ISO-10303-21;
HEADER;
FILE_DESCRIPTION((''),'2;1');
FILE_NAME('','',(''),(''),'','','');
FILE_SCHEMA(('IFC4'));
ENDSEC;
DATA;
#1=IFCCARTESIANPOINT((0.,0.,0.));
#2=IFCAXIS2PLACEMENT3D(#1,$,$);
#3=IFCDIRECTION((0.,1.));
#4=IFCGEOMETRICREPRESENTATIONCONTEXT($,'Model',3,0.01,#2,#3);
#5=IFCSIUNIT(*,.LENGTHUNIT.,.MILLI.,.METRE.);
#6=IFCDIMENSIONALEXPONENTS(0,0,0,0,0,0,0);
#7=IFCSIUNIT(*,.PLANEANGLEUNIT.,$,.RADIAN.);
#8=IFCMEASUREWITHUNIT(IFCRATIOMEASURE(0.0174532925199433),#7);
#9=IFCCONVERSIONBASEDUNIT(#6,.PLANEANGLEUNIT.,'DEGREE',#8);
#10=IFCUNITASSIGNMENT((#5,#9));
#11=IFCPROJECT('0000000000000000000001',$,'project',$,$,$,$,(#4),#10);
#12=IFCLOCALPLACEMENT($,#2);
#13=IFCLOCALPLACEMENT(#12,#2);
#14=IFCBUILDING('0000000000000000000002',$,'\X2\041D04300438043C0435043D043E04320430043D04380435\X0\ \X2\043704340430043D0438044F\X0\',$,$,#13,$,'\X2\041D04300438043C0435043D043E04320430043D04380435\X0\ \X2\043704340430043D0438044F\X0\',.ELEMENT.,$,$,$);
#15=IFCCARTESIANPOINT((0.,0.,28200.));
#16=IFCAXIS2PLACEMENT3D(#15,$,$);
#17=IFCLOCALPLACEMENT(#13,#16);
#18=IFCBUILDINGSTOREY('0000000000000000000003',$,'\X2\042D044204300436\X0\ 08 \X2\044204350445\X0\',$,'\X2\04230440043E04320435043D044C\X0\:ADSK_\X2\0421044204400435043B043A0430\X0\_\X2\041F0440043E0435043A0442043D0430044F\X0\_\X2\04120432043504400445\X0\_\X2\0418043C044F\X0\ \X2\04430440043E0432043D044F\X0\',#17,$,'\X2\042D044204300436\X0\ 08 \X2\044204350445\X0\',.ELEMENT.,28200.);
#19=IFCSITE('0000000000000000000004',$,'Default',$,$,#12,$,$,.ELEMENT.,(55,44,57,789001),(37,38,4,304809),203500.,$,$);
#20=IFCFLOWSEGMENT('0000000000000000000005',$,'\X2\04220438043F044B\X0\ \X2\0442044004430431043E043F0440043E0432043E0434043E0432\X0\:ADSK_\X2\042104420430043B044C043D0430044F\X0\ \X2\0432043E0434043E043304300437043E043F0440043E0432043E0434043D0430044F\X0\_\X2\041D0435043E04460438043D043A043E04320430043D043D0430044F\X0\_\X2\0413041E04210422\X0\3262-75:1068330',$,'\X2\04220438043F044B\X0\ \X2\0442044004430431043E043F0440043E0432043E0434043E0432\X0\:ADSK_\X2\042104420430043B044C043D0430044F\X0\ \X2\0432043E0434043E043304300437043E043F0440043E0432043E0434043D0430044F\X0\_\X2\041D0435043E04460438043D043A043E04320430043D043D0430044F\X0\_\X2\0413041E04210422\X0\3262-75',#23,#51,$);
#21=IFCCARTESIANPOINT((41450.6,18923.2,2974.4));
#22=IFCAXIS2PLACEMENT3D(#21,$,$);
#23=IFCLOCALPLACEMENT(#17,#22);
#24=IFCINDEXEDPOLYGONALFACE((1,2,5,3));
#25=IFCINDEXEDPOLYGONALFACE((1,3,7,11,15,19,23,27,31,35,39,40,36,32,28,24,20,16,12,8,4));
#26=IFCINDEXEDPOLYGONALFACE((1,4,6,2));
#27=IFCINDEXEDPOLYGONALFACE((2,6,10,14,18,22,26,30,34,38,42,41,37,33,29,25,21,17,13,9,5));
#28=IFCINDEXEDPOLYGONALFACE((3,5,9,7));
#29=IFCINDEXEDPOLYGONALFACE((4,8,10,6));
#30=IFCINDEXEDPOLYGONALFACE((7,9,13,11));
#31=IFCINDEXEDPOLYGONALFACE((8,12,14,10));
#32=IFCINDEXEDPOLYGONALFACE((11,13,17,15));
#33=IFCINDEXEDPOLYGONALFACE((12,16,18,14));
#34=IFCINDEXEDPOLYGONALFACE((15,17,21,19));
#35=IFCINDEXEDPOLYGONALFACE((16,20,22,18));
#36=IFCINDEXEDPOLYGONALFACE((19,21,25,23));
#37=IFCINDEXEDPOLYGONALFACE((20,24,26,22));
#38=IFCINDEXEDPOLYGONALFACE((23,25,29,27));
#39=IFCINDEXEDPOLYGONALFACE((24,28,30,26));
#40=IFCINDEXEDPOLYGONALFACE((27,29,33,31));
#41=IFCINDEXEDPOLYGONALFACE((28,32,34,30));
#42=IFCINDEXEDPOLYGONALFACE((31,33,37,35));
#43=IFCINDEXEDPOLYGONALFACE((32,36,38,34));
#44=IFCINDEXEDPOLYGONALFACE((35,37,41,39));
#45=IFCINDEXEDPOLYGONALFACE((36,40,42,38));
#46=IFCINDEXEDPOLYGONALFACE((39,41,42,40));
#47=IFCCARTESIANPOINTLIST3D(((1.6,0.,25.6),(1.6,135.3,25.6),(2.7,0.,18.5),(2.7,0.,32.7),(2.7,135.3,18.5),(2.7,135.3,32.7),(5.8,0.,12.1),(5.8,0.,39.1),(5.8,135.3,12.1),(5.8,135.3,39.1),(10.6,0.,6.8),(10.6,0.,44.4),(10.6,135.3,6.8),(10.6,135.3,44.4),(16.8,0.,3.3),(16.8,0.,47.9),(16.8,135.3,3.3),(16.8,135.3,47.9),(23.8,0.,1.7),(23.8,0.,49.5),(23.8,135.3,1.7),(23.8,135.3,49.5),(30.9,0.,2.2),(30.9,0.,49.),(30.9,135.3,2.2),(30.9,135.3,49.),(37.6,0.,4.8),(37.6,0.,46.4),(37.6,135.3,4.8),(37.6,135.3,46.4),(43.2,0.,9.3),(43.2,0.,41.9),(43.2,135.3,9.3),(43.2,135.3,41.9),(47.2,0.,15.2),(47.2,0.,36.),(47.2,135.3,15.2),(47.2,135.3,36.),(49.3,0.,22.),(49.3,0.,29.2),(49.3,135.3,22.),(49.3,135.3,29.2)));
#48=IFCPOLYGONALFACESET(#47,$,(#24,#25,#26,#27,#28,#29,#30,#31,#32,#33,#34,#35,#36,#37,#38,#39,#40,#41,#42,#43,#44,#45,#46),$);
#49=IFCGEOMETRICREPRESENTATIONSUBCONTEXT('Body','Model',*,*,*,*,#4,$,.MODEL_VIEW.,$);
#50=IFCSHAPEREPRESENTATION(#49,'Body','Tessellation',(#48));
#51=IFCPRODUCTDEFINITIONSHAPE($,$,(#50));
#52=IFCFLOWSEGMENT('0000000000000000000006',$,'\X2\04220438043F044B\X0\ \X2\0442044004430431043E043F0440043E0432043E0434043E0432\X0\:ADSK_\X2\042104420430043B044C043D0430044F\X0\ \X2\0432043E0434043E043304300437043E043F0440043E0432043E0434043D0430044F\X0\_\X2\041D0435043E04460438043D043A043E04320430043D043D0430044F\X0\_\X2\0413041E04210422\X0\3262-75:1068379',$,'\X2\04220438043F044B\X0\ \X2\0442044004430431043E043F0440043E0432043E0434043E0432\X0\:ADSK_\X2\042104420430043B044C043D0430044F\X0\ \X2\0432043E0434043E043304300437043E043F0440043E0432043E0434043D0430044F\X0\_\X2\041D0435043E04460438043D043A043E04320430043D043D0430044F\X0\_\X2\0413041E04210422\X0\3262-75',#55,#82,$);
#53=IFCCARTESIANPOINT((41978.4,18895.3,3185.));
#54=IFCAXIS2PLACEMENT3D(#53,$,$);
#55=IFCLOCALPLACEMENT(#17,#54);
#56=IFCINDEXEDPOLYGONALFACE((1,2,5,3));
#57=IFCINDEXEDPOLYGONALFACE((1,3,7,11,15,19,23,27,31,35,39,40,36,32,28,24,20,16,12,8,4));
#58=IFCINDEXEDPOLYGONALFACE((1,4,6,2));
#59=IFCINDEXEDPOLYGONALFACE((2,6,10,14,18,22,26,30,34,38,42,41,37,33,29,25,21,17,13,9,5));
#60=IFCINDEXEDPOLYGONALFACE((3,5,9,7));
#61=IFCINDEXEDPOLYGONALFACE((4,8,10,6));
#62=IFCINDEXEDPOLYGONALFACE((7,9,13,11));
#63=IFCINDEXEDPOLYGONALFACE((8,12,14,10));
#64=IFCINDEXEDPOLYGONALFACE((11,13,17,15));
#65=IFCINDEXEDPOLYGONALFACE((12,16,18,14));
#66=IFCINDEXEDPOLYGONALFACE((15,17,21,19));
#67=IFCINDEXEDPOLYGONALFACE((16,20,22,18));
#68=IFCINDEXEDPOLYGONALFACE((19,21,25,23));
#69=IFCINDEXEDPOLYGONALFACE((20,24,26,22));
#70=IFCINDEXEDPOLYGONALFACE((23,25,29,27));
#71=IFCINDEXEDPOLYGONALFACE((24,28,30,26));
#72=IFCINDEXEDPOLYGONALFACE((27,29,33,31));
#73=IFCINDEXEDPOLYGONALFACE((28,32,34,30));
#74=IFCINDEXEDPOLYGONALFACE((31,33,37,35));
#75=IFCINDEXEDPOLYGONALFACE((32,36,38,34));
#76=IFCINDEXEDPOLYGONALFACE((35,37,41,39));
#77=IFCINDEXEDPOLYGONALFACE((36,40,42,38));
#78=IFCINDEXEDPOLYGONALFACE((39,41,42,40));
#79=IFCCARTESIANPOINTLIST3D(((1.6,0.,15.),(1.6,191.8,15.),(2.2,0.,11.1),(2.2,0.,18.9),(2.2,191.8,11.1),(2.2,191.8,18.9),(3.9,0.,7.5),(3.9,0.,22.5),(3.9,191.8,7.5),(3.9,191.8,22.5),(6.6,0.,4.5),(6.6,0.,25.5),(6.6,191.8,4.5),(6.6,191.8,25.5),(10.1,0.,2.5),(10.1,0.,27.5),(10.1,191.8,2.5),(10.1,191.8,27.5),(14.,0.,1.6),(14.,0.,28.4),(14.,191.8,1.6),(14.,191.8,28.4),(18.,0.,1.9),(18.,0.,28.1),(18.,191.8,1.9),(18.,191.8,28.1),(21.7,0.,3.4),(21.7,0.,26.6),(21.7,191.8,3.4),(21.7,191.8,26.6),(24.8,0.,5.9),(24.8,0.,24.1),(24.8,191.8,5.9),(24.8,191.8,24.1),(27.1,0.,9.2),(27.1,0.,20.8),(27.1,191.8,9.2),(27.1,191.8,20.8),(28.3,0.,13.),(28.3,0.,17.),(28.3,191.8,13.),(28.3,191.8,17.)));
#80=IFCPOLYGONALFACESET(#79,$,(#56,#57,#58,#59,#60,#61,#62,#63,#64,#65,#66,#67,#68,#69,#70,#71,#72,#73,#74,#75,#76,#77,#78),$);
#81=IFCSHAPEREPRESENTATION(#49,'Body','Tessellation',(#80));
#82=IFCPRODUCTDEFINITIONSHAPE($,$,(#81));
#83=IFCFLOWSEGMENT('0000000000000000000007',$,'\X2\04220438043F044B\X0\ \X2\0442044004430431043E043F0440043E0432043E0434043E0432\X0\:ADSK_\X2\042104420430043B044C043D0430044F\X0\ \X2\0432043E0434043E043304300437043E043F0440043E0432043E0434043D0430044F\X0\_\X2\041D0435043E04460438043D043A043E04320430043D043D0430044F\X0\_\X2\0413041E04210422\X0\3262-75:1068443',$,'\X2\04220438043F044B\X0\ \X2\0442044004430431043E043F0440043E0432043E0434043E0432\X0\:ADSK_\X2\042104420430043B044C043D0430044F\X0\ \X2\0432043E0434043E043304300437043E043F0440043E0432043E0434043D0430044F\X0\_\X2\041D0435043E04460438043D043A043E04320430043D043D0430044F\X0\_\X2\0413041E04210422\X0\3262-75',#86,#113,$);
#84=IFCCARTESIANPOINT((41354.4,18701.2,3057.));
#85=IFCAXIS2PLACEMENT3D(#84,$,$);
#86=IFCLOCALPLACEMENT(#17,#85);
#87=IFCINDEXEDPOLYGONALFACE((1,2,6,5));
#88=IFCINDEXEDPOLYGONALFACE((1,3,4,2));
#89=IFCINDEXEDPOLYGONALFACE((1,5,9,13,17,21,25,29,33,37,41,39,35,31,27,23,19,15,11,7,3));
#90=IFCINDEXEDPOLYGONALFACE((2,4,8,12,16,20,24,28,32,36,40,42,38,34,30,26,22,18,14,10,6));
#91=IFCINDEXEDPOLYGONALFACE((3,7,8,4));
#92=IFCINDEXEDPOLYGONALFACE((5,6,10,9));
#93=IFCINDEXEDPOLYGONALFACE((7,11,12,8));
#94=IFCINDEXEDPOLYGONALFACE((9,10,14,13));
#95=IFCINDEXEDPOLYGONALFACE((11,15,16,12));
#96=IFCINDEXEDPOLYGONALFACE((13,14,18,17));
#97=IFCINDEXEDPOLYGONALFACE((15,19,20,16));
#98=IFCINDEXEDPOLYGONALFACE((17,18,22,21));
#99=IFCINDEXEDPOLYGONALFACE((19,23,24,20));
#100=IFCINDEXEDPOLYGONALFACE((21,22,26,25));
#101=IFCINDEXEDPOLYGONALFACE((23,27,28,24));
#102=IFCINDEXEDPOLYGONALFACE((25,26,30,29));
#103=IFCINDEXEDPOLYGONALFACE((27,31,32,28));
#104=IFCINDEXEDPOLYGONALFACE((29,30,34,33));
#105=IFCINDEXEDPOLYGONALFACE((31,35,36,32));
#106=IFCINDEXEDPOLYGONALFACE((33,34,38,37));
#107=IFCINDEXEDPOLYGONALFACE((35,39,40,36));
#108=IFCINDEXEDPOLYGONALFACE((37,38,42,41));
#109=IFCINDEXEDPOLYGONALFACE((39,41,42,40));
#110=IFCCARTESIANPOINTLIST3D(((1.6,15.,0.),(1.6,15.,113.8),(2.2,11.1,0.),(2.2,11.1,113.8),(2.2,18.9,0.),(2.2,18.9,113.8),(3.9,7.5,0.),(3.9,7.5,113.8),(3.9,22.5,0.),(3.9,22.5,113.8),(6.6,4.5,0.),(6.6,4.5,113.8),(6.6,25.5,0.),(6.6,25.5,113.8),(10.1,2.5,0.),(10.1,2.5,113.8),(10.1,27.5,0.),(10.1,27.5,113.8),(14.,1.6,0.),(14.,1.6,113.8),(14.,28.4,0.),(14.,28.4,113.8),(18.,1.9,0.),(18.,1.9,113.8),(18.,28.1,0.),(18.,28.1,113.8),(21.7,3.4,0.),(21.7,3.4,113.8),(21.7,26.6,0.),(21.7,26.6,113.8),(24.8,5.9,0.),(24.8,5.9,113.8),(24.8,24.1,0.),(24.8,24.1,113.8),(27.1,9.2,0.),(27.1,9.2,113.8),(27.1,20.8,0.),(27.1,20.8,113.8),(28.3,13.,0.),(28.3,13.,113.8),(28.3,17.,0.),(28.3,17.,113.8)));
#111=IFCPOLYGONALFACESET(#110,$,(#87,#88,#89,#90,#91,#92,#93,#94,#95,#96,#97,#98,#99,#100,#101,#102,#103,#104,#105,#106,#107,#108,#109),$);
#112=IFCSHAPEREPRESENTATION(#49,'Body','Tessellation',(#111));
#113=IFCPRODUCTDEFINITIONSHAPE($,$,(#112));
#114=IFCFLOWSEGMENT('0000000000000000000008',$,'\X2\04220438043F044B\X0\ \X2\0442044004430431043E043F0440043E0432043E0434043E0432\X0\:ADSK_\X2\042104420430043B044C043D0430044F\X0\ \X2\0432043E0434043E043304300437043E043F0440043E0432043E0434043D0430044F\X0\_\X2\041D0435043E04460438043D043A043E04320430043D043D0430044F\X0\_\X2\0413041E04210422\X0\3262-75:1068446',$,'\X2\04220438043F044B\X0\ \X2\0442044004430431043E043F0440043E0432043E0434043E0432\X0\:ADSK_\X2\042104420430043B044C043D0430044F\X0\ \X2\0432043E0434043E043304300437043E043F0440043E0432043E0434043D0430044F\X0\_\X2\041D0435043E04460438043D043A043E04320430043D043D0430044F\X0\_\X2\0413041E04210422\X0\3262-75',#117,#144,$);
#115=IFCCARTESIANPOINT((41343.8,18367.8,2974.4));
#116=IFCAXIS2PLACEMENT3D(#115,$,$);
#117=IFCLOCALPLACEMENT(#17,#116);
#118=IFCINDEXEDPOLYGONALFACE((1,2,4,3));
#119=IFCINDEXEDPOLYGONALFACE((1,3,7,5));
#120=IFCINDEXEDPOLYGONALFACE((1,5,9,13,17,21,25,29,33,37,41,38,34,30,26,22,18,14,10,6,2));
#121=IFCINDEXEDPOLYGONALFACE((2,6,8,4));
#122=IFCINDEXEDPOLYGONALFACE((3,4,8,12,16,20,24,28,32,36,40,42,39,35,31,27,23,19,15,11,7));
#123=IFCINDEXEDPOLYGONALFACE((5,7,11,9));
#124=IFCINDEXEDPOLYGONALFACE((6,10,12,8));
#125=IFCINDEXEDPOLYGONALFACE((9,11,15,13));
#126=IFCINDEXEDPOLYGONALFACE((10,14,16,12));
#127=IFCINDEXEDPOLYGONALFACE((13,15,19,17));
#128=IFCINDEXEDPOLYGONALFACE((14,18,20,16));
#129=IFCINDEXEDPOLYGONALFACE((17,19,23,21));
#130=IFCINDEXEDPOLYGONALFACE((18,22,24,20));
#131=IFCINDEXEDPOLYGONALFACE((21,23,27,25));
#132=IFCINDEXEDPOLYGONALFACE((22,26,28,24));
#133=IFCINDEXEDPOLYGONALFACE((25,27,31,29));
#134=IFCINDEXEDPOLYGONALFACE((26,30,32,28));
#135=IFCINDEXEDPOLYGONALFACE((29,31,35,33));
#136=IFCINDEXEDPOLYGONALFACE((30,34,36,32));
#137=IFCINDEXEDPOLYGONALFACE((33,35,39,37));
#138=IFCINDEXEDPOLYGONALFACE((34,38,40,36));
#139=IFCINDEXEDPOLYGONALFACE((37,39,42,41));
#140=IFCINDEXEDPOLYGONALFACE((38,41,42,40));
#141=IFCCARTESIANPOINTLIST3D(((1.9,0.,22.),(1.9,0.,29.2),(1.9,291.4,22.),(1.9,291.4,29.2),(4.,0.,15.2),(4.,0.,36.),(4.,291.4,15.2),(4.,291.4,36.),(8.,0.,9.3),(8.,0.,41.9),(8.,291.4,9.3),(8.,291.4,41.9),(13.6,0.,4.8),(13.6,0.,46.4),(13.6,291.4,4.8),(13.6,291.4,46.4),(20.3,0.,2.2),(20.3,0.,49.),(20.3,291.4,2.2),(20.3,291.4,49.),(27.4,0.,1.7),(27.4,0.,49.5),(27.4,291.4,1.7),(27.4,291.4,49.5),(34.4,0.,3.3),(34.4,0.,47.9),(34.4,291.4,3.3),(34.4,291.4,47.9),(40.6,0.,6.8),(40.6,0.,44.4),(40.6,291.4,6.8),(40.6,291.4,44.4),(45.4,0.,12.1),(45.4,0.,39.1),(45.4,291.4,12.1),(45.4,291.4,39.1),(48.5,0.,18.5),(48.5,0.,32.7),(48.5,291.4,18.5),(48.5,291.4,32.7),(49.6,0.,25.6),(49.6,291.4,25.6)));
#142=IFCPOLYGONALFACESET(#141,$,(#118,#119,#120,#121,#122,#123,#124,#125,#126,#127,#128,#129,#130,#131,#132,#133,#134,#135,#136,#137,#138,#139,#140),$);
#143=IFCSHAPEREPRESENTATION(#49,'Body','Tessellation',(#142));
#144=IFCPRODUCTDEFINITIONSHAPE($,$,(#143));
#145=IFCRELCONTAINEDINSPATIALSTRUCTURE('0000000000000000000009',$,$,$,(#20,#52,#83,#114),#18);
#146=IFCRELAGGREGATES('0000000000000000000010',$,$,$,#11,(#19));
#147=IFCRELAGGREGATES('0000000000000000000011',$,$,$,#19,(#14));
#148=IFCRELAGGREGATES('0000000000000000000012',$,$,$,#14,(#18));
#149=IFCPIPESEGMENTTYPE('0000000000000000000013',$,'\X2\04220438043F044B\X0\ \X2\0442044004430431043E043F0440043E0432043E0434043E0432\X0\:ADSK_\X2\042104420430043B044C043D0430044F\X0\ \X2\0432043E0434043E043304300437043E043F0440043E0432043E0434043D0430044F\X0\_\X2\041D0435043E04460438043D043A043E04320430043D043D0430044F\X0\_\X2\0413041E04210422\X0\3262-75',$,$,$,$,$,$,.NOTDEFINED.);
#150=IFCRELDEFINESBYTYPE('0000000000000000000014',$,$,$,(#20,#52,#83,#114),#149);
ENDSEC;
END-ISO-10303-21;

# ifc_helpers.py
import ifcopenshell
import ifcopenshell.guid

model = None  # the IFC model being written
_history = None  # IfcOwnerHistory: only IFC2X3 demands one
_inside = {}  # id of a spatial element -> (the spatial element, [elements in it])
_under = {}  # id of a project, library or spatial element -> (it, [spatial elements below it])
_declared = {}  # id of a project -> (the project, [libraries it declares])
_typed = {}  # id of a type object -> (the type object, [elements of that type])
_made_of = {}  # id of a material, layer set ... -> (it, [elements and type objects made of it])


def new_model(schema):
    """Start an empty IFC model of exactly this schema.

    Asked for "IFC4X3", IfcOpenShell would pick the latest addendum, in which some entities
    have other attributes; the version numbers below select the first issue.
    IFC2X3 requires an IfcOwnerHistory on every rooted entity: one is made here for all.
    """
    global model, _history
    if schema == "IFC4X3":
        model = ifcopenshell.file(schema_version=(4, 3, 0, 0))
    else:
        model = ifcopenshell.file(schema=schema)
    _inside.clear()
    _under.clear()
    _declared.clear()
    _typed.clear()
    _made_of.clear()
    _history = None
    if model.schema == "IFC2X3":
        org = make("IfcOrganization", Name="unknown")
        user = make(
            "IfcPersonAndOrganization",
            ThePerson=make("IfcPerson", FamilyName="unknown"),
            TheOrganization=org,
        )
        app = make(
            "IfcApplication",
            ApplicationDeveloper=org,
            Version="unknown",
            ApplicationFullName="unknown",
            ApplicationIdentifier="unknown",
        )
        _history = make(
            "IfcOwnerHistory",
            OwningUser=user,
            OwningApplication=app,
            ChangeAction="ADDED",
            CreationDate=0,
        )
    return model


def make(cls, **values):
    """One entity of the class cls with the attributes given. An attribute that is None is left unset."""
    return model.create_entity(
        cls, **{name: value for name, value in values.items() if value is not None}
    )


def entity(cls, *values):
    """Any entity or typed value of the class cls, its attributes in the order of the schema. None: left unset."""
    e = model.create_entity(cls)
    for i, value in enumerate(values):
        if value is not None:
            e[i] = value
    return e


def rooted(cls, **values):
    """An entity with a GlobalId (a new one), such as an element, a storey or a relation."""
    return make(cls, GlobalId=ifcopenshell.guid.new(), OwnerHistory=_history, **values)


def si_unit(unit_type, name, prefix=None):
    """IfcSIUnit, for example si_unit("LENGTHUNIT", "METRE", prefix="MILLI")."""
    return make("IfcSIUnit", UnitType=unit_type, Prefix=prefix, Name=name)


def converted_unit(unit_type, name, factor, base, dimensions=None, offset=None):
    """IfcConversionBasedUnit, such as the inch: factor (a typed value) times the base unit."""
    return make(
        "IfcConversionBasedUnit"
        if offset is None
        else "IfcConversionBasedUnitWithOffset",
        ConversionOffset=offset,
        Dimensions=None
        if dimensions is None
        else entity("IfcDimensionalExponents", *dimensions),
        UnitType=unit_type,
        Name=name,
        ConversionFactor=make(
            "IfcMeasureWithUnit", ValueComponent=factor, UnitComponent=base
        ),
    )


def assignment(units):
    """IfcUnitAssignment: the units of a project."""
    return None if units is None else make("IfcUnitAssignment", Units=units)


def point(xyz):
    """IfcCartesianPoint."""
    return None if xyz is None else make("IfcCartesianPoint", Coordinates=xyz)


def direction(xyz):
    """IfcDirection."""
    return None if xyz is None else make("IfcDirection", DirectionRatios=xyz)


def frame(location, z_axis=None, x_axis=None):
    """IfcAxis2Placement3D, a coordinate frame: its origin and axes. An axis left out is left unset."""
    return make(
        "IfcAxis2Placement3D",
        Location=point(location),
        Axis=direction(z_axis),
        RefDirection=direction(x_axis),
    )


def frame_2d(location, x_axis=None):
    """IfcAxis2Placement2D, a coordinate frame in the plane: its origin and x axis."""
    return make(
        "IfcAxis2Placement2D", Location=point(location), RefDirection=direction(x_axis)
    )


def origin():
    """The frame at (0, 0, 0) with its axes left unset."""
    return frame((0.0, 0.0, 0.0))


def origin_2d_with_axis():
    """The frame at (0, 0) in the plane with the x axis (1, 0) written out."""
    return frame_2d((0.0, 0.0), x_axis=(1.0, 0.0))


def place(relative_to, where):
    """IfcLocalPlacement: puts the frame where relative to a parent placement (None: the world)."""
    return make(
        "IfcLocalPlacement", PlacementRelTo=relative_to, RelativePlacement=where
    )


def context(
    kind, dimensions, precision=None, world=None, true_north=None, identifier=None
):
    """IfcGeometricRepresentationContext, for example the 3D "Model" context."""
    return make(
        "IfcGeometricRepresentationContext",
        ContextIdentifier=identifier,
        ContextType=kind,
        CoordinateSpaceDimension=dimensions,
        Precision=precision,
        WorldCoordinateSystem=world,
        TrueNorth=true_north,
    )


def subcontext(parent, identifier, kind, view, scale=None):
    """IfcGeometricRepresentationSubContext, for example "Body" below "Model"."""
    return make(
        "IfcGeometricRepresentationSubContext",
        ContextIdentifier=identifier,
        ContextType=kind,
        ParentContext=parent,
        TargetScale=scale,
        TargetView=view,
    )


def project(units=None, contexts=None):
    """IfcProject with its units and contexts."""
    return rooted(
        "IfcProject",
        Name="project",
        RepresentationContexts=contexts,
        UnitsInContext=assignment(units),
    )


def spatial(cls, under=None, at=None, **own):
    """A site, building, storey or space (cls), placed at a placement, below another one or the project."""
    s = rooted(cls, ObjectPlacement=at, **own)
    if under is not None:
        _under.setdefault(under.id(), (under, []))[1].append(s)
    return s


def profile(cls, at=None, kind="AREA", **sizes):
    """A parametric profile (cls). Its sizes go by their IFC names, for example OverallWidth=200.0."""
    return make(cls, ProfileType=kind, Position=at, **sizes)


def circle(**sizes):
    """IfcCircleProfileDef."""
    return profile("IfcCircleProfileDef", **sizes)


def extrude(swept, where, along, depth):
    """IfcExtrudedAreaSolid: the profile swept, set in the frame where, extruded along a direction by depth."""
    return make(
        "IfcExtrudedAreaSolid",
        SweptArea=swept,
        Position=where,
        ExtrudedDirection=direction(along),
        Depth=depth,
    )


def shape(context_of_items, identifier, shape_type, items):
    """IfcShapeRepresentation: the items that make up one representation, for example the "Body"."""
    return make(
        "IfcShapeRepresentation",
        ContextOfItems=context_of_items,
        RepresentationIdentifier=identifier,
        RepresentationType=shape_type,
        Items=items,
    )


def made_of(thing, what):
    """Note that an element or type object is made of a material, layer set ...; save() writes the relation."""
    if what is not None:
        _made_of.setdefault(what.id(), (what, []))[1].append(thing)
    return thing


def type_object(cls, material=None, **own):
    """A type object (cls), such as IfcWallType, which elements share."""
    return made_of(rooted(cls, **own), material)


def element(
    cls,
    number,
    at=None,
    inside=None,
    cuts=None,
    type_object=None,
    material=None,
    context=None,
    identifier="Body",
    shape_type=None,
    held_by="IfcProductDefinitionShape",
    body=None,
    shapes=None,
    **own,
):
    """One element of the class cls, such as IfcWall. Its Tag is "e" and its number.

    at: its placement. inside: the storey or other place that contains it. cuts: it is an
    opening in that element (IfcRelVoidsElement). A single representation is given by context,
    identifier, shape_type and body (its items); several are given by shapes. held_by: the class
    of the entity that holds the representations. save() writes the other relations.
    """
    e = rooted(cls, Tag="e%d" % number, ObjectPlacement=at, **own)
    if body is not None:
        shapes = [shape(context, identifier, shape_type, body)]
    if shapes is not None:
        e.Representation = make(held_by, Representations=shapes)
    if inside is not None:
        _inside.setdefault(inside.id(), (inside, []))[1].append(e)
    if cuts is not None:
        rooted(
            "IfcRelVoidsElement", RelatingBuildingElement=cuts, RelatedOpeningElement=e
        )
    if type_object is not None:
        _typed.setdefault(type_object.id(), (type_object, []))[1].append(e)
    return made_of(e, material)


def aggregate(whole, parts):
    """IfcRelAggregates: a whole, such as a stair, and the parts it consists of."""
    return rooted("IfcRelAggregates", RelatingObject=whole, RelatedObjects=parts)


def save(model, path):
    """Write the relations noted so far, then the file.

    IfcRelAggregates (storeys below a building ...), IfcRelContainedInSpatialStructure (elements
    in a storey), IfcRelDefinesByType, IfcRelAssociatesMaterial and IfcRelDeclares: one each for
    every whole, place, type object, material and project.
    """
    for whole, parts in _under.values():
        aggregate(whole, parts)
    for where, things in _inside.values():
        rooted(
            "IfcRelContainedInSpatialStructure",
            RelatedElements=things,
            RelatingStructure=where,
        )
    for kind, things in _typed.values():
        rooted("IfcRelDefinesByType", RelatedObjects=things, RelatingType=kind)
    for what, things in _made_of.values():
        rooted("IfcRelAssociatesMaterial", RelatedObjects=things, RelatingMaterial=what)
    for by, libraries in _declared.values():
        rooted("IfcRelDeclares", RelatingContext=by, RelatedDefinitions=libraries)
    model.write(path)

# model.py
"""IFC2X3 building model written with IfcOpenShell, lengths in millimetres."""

from ifc_helpers import new_model, entity, si_unit, converted_unit, direction, frame, origin, origin_2d_with_axis, place, context, subcontext, project, spatial, circle, extrude, type_object, element, save


model = new_model("IFC2X3")

# Units and contexts
model_context = context("Model", 3, precision=0.01, world=origin(), true_north=direction((0.0, 1.0)))
body_context = subcontext(model_context, "Body", "Model", "MODEL_VIEW")
ifc_project = project(units=[si_unit("LENGTHUNIT", "METRE", prefix="MILLI"), converted_unit("PLANEANGLEUNIT", "DEGREE", entity("IfcRatioMeasure", 0.0174532925199433), si_unit("PLANEANGLEUNIT", "RADIAN"), dimensions=[0, 0, 0, 0, 0, 0, 0])], contexts=[model_context])

# Site, building, storey
site_placement = place(None, origin())
site = spatial("IfcSite", under=ifc_project, at=site_placement, Name="Default", CompositionType="ELEMENT", RefLatitude=(55, 44, 57, 789001), RefLongitude=(37, 38, 4, 304809), RefElevation=203500.0)
building_placement = place(site_placement, origin())
building = spatial("IfcBuilding", under=site, at=building_placement, Name="Наименование здания", LongName="Наименование здания", CompositionType="ELEMENT")
storey_placement = place(building_placement, frame((0.0, 0.0, 28200.0)))
storey = spatial("IfcBuildingStorey", under=building, at=storey_placement, Name="Этаж 08 тех", ObjectType="Уровень:ADSK_Стрелка_Проектная_Вверх_Имя уровня", LongName="Этаж 08 тех", CompositionType="ELEMENT", Elevation=28200.0)

# Flow segments
pipe_segment_type = type_object("IfcPipeSegmentType", Name="Типы трубопроводов:ADSK_Стальная водогазопроводная_Неоцинкованная_ГОСТ3262-75", PredefinedType="NOTDEFINED")
flow_segment_1_placement = place(storey_placement, frame((41450.6, 18923.2, 2974.4)))
element("IfcFlowSegment", 1, at=flow_segment_1_placement, inside=storey, type_object=pipe_segment_type, Name="Типы трубопроводов:ADSK_Стальная водогазопроводная_Неоцинкованная_ГОСТ3262-75:1068330", ObjectType="Типы трубопроводов:ADSK_Стальная водогазопроводная_Неоцинкованная_ГОСТ3262-75", context=body_context, shape_type="SweptSolid", body=[
    extrude(circle(Radius=24.0, at=origin_2d_with_axis()), frame((25.6, 0.0, 25.6), z_axis=(0.0, 1.0, 0.0), x_axis=(-1.0, 0.0, 0.0)), (0.0, 0.0, 1.0), 135.3),
])
flow_segment_2_placement = place(storey_placement, frame((41978.4, 18895.3, 3185.0)))
element("IfcFlowSegment", 2, at=flow_segment_2_placement, inside=storey, type_object=pipe_segment_type, Name="Типы трубопроводов:ADSK_Стальная водогазопроводная_Неоцинкованная_ГОСТ3262-75:1068379", ObjectType="Типы трубопроводов:ADSK_Стальная водогазопроводная_Неоцинкованная_ГОСТ3262-75", context=body_context, shape_type="SweptSolid", body=[
    extrude(circle(Radius=13.4, at=origin_2d_with_axis()), frame((15.0, 0.0, 15.0), z_axis=(0.0, 1.0, 0.0), x_axis=(-1.0, 0.0, 0.0)), (0.0, 0.0, 1.0), 191.8),
])
flow_segment_3_placement = place(storey_placement, frame((41354.4, 18701.2, 3057.0)))
element("IfcFlowSegment", 3, at=flow_segment_3_placement, inside=storey, type_object=pipe_segment_type, Name="Типы трубопроводов:ADSK_Стальная водогазопроводная_Неоцинкованная_ГОСТ3262-75:1068443", ObjectType="Типы трубопроводов:ADSK_Стальная водогазопроводная_Неоцинкованная_ГОСТ3262-75", context=body_context, shape_type="SweptSolid", body=[
    extrude(circle(Radius=13.4, at=origin_2d_with_axis()), frame((15.0, 15.0, 0.0), z_axis=(0.0, 0.0, 1.0), x_axis=(-1.0, 0.0, 0.0)), (0.0, 0.0, 1.0), 113.8),
])
flow_segment_4_placement = place(storey_placement, frame((41343.8, 18367.8, 2974.4)))
element("IfcFlowSegment", 4, at=flow_segment_4_placement, inside=storey, type_object=pipe_segment_type, Name="Типы трубопроводов:ADSK_Стальная водогазопроводная_Неоцинкованная_ГОСТ3262-75:1068446", ObjectType="Типы трубопроводов:ADSK_Стальная водогазопроводная_Неоцинкованная_ГОСТ3262-75", context=body_context, shape_type="SweptSolid", body=[
    extrude(circle(Radius=24.0, at=origin_2d_with_axis()), frame((25.6, 0.0, 25.6), z_axis=(0.0, 1.0, 0.0), x_axis=(1.0, 0.0, 0.0)), (0.0, 0.0, 1.0), 291.4),
])

save(model, "model.ifc")
